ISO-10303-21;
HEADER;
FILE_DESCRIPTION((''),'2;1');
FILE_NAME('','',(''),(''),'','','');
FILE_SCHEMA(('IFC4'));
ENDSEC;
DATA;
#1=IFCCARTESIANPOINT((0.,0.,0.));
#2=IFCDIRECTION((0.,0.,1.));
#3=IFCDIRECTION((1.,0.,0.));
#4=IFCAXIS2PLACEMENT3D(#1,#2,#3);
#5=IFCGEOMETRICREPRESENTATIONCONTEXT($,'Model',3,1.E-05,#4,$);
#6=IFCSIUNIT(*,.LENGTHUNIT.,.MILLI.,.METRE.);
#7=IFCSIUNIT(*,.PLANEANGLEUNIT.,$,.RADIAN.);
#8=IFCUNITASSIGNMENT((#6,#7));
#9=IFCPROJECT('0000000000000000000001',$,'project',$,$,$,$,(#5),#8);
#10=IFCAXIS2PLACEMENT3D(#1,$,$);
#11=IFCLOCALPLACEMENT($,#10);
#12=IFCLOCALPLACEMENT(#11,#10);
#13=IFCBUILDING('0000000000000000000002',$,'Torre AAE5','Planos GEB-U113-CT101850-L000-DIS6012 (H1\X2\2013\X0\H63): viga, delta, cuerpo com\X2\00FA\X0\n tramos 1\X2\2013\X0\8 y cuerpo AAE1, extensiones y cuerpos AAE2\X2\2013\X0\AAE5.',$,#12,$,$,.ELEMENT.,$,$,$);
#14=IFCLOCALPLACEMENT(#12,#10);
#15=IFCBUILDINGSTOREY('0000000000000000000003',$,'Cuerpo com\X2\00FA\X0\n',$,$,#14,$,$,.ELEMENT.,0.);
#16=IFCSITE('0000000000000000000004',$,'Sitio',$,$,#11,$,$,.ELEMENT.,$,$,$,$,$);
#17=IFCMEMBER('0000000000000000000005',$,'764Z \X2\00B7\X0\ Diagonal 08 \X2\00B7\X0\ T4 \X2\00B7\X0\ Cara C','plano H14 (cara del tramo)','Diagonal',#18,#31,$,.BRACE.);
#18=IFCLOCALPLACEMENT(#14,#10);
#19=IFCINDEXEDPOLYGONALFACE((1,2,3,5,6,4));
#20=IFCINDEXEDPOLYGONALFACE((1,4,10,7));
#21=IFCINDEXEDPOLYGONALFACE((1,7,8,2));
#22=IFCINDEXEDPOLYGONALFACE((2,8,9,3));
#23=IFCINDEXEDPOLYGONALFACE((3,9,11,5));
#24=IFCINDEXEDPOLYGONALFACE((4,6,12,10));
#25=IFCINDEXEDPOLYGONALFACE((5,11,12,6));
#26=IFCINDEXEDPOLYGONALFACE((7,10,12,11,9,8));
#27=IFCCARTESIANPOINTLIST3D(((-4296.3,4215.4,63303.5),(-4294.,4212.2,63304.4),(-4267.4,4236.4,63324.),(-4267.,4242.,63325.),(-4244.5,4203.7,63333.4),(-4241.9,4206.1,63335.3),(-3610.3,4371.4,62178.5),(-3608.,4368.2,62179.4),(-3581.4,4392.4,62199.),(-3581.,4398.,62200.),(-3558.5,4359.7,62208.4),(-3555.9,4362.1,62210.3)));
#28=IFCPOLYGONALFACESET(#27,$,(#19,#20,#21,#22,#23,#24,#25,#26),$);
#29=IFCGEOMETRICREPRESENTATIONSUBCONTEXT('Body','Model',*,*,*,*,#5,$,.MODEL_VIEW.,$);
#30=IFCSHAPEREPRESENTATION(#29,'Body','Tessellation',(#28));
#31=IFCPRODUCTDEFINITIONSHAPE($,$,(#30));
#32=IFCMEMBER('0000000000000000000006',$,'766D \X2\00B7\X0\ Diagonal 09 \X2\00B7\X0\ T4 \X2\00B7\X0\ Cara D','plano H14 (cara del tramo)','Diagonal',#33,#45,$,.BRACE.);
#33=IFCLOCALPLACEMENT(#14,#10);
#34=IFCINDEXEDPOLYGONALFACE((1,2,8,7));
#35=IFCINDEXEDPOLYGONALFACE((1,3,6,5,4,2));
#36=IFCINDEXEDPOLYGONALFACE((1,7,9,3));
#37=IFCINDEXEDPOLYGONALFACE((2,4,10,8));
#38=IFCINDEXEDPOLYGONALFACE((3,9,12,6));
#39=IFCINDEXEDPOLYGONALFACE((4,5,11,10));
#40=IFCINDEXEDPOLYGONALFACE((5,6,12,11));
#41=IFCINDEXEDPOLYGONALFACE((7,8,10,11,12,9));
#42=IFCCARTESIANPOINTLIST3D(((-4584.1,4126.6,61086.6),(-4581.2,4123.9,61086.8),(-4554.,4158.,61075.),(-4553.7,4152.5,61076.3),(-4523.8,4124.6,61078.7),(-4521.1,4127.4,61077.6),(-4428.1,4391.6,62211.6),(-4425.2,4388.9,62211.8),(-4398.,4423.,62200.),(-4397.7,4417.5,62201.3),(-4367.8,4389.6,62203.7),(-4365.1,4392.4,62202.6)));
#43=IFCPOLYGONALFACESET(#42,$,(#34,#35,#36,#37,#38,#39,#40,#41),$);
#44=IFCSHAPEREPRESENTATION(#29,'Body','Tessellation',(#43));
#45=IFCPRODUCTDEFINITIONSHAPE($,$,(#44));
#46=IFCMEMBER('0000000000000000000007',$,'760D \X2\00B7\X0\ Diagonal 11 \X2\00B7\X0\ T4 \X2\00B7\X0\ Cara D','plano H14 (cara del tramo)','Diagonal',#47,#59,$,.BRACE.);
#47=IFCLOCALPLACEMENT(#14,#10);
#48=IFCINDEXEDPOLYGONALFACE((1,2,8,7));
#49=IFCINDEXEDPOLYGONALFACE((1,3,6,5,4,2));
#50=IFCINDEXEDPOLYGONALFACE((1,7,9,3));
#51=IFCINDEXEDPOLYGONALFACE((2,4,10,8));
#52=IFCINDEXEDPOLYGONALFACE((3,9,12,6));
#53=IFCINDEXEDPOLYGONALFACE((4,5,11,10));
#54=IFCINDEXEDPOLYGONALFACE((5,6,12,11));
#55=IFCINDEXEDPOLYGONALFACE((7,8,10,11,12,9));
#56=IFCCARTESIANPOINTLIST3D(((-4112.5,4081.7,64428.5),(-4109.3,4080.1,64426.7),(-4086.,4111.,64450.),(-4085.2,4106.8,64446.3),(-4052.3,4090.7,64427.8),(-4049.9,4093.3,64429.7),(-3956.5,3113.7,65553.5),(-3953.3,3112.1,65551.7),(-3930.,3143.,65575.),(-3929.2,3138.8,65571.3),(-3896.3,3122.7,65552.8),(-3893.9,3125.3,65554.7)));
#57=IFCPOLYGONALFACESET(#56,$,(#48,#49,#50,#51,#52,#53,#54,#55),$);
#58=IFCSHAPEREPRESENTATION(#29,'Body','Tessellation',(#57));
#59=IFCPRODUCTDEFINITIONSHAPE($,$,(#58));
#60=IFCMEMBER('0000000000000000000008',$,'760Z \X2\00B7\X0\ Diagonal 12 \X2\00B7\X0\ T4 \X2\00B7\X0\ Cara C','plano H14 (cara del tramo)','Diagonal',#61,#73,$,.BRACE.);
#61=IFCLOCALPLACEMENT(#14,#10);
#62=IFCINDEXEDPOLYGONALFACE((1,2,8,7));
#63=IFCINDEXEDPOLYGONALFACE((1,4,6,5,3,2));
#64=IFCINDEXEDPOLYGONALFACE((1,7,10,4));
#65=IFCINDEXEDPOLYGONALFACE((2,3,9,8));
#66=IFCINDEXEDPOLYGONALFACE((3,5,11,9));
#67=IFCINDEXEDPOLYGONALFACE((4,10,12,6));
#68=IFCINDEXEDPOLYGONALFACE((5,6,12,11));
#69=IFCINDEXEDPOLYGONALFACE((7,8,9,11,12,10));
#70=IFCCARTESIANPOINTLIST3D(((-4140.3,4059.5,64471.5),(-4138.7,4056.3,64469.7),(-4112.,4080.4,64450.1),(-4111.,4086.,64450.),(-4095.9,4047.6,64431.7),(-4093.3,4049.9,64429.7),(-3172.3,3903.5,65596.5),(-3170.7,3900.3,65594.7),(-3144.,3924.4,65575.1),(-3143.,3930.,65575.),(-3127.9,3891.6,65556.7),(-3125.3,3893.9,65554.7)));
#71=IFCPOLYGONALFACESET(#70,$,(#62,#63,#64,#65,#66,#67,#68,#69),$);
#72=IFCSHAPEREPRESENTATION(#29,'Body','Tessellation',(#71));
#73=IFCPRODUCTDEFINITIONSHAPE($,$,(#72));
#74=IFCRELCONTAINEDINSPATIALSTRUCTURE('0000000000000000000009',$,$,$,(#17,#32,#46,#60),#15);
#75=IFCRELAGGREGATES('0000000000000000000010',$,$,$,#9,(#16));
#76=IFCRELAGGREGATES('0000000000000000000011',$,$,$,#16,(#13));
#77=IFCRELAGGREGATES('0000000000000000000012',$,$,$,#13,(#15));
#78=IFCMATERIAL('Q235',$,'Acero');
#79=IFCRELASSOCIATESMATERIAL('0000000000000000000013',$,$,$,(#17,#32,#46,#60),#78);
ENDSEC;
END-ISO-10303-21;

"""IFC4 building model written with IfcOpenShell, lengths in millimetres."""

from ifc_helpers import new_model, si_unit, frame, frame_2d, origin, origin_with_axes, place, context, subcontext, project, spatial, l_section, extrude, material, element, save


model = new_model("IFC4")

# Units and contexts
model_context = context("Model", 3, precision=1e-05, world=origin_with_axes())
body_context = subcontext(model_context, "Body", "Model", "MODEL_VIEW")
ifc_project = project(units=[si_unit("LENGTHUNIT", "METRE", prefix="MILLI"), si_unit("PLANEANGLEUNIT", "RADIAN")], contexts=[model_context])

# Site, building, storey
site_placement = place(None, origin())
site = spatial("IfcSite", under=ifc_project, at=site_placement, Name="Sitio", CompositionType="ELEMENT")
building_placement = place(site_placement, origin())
building = spatial("IfcBuilding", under=site, at=building_placement, Name="Torre AAE5", Description="Planos GEB-U113-CT101850-L000-DIS6012 (H1–H63): viga, delta, cuerpo común tramos 1–8 y cuerpo AAE1, extensiones y cuerpos AAE2–AAE5.", CompositionType="ELEMENT")
storey_placement = place(building_placement, origin())
storey = spatial("IfcBuildingStorey", under=building, at=storey_placement, Name="Cuerpo común", CompositionType="ELEMENT", Elevation=0.0)

# Members
ifc_material_1 = material(Name="Q235", Category="Acero")
for number, where, z_axis, x_axis, name in (
    (1, (-4267.0, 4242.0, 63325.0), (0.51701, 0.117571, -0.847867), (0.556878, -0.798444, 0.228854), "764Z · Diagonal 08 · T4 · Cara C"),
):
    element("IfcMember", number, at=place(storey_placement, frame(where, z_axis=z_axis, x_axis=x_axis)), inside=storey, material=ifc_material_1, Name=name, Description="plano H14 (cara del tramo)", ObjectType="Diagonal", PredefinedType="BRACE", context=body_context, shape_type="SweptSolid", body=[
        extrude(l_section(Depth=45.0, Width=45.0, Thickness=4.0, at=frame_2d((22.5, 22.5))), None, (0.0, 0.0, 1.0), 1326.9),
    ])
member_1_placement = place(storey_placement, frame((-4398.0, 4423.0, 62200.0), z_axis=(-0.13376, -0.22722, -0.964614), x_axis=(0.73137, -0.679455, 0.058633)))
element("IfcMember", 2, at=member_1_placement, inside=storey, material=ifc_material_1, Name="766D · Diagonal 09 · T4 · Cara D", Description="plano H14 (cara del tramo)", ObjectType="Diagonal", PredefinedType="BRACE", context=body_context, shape_type="SweptSolid", body=[
    extrude(l_section(Depth=45.0, Width=45.0, Thickness=4.0, at=frame_2d((22.5, 22.5))), None, (0.0, 0.0, 1.0), 1166.3),
])
for number, where, z_axis, x_axis, name in (
    (3, (-3930.0, 3143.0, 65575.0), (-0.104536, 0.648659, -0.753866), (0.801211, -0.394141, -0.450238), "760D · Diagonal 11 · T4 · Cara D"),
    (4, (-3143.0, 3930.0, 65575.0), (-0.648659, 0.104536, -0.753866), (0.394141, -0.801211, -0.450238), "760Z · Diagonal 12 · T4 · Cara C"),
):
    element("IfcMember", number, at=place(storey_placement, frame(where, z_axis=z_axis, x_axis=x_axis)), inside=storey, material=ifc_material_1, Name=name, Description="plano H14 (cara del tramo)", ObjectType="Diagonal", PredefinedType="BRACE", context=body_context, shape_type="SweptSolid", body=[
        extrude(l_section(Depth=45.0, Width=45.0, Thickness=4.0, at=frame_2d((22.5, 22.5))), None, (0.0, 0.0, 1.0), 1492.3),
    ])

save(model, "model.ifc")
